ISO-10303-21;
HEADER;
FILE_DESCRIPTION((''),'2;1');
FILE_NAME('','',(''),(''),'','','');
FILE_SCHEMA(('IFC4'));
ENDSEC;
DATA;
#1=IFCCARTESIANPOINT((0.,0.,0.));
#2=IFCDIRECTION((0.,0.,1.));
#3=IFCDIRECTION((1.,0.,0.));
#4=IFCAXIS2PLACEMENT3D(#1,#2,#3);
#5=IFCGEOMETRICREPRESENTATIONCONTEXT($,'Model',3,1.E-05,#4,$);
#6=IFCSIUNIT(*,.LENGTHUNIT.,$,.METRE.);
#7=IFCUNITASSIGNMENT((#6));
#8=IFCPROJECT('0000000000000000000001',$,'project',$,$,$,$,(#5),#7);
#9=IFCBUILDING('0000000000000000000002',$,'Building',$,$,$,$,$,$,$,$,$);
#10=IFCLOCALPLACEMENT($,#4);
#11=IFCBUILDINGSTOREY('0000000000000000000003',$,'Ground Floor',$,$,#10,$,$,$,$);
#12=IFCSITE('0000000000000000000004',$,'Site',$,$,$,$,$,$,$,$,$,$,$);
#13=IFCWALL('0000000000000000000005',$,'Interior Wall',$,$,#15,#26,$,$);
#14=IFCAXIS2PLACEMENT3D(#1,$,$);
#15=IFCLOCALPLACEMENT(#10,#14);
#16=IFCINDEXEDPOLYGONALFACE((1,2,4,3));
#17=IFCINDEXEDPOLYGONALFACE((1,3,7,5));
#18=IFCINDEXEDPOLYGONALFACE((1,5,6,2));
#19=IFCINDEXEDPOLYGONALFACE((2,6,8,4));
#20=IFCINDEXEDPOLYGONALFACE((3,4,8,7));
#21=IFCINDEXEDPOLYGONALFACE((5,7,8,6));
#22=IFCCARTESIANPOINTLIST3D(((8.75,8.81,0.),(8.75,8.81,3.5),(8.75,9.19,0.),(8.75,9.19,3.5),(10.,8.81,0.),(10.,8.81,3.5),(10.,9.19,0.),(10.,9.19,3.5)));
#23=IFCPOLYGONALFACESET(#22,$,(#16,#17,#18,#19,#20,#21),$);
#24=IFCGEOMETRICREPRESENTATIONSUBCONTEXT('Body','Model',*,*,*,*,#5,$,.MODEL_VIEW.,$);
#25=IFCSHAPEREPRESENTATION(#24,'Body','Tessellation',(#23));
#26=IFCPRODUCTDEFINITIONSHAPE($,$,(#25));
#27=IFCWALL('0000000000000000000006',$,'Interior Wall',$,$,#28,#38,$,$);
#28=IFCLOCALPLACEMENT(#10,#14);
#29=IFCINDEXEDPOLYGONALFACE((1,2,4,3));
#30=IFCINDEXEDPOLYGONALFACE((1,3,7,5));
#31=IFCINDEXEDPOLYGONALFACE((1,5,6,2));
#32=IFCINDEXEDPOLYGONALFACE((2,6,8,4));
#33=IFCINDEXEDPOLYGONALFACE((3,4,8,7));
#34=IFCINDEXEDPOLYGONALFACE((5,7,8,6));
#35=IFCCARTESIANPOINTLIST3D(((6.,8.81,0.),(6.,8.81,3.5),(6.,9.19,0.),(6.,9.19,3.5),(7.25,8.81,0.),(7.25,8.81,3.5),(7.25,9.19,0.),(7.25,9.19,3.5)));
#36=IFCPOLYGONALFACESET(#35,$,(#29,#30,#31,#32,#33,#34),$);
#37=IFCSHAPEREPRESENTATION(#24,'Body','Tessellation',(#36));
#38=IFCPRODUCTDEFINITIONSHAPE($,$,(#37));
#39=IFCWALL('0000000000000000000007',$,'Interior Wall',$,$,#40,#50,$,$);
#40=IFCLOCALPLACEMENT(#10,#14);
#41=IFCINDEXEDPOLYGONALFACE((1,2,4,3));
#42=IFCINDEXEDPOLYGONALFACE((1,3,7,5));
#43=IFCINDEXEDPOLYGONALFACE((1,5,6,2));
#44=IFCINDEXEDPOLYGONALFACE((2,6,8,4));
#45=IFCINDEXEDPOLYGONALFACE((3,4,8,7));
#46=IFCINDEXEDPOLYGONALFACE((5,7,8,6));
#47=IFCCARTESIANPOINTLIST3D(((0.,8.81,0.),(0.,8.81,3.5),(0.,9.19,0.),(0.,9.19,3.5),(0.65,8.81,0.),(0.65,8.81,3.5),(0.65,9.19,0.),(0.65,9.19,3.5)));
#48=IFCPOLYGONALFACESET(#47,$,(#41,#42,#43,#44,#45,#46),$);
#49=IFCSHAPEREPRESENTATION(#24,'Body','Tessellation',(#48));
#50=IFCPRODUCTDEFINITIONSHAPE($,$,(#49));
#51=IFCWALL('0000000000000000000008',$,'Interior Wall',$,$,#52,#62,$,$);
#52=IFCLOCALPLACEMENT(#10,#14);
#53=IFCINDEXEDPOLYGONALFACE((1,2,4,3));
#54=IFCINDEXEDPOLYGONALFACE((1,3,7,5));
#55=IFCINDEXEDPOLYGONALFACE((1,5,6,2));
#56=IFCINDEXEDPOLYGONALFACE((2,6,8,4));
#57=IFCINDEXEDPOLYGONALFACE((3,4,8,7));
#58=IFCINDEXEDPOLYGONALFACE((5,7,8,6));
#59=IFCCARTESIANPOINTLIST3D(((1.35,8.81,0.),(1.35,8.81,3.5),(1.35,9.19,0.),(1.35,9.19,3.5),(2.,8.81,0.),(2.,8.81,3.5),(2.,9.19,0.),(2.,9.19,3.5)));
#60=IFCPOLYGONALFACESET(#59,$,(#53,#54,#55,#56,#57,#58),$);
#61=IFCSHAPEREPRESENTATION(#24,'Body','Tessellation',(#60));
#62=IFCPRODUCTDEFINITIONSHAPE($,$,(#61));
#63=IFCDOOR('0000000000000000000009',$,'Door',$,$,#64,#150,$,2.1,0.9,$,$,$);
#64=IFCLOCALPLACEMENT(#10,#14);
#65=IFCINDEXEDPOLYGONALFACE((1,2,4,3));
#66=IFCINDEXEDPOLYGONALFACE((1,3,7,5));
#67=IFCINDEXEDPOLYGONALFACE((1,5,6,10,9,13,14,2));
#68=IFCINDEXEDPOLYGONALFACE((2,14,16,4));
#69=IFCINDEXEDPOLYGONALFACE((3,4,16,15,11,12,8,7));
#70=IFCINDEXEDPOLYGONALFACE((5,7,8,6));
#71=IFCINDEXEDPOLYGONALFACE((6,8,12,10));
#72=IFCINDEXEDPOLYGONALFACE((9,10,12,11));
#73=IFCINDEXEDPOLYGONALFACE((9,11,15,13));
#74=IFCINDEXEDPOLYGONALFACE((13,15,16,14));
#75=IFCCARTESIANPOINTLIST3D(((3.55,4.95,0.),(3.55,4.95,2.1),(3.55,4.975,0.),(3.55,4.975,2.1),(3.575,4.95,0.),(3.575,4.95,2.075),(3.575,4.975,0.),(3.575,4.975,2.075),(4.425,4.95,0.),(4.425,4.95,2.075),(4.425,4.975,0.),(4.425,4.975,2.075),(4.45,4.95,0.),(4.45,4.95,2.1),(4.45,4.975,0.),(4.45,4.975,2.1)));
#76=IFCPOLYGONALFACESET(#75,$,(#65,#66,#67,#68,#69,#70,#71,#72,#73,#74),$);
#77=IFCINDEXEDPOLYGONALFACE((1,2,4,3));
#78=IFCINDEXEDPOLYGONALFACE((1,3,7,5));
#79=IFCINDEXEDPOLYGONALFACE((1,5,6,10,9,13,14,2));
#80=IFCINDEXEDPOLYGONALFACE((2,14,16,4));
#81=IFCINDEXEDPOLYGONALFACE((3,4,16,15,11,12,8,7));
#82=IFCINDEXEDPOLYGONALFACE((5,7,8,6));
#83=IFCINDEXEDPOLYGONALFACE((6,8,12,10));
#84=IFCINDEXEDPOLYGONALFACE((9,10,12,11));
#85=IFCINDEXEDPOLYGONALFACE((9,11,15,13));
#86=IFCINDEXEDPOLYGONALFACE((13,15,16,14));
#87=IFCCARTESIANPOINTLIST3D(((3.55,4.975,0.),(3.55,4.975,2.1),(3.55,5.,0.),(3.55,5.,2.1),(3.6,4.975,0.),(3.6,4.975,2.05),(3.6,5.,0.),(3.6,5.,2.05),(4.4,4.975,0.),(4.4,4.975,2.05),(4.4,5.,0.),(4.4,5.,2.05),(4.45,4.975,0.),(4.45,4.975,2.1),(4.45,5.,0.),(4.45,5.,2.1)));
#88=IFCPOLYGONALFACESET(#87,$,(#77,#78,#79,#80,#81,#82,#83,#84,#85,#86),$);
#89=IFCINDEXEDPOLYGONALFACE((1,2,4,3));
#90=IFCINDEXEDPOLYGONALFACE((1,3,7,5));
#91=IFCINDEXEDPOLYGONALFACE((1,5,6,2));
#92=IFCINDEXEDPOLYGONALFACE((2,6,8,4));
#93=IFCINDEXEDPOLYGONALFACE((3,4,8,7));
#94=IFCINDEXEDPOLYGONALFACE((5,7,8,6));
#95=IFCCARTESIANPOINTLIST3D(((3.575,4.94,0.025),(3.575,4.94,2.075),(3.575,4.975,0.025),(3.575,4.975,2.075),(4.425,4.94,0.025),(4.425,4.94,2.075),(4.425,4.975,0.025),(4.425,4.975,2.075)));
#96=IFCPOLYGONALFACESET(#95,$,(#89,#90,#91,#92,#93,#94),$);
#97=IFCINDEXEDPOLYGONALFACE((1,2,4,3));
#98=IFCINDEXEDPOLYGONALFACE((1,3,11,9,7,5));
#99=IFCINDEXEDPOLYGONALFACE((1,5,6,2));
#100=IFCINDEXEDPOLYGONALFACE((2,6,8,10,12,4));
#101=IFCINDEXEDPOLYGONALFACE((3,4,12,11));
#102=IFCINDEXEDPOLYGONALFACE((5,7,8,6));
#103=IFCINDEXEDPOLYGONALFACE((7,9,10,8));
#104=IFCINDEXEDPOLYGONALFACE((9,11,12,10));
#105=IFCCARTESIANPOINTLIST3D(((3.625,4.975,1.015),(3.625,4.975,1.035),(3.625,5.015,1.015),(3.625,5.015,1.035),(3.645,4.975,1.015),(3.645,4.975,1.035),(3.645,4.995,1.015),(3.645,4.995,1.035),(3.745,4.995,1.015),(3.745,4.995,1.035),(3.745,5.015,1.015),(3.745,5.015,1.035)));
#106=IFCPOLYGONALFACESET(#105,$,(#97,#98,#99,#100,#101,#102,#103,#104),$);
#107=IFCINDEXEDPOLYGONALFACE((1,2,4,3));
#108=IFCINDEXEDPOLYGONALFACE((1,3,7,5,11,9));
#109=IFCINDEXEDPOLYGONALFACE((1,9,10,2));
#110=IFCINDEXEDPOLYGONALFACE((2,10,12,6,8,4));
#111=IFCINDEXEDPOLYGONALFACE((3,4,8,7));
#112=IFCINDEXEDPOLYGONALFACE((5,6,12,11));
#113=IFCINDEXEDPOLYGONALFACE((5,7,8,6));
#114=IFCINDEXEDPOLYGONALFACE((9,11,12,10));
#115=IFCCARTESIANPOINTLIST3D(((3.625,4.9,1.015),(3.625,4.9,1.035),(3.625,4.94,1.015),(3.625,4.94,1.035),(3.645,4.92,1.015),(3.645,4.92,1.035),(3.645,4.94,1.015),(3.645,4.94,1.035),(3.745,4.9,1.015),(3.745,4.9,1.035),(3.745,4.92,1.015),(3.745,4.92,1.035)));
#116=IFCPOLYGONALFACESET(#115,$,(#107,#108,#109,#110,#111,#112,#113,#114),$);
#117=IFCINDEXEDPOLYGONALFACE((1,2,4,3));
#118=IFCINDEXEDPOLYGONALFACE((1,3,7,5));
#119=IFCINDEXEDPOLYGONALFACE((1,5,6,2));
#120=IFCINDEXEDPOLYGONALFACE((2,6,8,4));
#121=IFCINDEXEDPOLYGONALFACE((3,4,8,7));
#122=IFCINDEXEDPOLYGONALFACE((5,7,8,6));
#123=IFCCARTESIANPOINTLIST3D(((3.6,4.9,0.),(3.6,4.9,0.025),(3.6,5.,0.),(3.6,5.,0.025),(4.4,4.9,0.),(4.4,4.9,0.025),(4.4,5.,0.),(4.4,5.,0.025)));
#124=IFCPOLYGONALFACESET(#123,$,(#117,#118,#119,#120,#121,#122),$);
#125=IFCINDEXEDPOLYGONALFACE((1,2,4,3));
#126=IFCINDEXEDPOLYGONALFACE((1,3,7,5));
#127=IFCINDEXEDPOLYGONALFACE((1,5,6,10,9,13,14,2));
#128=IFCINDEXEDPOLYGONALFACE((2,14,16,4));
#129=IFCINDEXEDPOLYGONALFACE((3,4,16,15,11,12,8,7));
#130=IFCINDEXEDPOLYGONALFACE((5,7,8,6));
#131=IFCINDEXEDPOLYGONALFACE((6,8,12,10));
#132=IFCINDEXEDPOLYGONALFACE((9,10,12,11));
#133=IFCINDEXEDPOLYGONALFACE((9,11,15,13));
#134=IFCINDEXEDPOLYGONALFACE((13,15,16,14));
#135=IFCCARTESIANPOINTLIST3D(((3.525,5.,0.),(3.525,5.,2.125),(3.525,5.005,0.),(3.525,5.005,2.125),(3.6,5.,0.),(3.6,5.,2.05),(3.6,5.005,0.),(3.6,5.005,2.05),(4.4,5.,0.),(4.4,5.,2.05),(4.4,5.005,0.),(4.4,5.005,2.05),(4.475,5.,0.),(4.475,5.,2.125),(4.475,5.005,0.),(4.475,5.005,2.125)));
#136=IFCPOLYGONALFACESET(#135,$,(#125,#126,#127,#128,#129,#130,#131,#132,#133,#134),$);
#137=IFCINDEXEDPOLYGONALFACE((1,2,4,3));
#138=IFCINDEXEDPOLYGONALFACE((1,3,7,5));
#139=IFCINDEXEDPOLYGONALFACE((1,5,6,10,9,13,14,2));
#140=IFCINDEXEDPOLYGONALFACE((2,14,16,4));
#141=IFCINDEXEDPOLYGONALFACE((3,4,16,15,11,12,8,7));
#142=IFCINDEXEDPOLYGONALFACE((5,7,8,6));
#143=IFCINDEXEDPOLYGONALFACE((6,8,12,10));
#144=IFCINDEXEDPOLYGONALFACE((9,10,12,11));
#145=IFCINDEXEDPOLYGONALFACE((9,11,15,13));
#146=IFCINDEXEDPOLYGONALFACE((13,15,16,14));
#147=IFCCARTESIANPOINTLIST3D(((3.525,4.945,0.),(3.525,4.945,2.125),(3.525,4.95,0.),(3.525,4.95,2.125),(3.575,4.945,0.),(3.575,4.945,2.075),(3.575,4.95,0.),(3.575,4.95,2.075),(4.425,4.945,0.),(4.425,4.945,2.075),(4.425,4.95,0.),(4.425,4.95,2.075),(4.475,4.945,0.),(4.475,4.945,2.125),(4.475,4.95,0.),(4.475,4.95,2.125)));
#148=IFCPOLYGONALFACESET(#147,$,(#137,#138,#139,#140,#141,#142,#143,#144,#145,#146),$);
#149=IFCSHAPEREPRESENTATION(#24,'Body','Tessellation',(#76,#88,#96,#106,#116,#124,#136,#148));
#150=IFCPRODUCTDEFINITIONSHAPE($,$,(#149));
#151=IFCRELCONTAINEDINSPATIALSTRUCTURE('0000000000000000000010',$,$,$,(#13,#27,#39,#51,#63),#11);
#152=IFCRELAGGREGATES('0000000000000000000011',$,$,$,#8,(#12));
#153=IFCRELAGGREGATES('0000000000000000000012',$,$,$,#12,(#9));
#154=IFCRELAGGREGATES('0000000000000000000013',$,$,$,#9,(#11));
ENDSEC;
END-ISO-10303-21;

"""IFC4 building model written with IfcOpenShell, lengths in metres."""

from ifc_helpers import new_model, si_unit, frame, origin_with_axes, place, context, subcontext, project, spatial, line, indexed_curve, outline, extrude, element, save


model = new_model("IFC4")

# Units and contexts
model_context = context("Model", 3, precision=1e-05, world=origin_with_axes())
body_context = subcontext(model_context, "Body", "Model", "MODEL_VIEW")
ifc_project = project(units=[si_unit("LENGTHUNIT", "METRE")], contexts=[model_context])

# Site, building, storey
site = spatial("IfcSite", under=ifc_project, Name="Site")
building = spatial("IfcBuilding", under=site, Name="Building")
storey_placement = place(None, origin_with_axes())
storey = spatial("IfcBuildingStorey", under=building, at=storey_placement, Name="Ground Floor")

# Walls
for number, where, z_axis, x_axis, name in (
    (1, (10.0, 9.0, 0.0), (0.0, 0.0, 1.0), (-1.0, 0.0, 0.0), "Interior Wall"),
    (2, (7.25, 9.0, 0.0), (0.0, 0.0, 1.0), (-1.0, 0.0, 0.0), "Interior Wall"),
):
    element("IfcWall", number, at=place(storey_placement, frame(where, z_axis=z_axis, x_axis=x_axis)), inside=storey, Name=name, context=body_context, shape_type="SweptSolid", body=[
        extrude(outline(indexed_curve([(0.0, 0.0), (0.0, 0.38), (1.25, 0.38), (1.25, 0.0), (0.0, 0.0)], self_intersect=False)), frame((0.0, -0.19, 0.0), z_axis=(0.0, 0.0, 1.0), x_axis=(1.0, 0.0, 0.0)), (0.0, 0.0, 1.0), 3.5),
    ])
wall_1_placement = place(storey_placement, frame((0.0, 9.0, 0.0), z_axis=(0.0, 0.0, 1.0), x_axis=(1.0, 0.0, 0.0)))
element("IfcWall", 3, at=wall_1_placement, inside=storey, Name="Interior Wall", context=body_context, shape_type="SweptSolid", body=[
    extrude(outline(indexed_curve([(0.0, 0.0), (0.0, 0.38), (0.65, 0.38), (0.65, 0.0), (0.0, 0.0)], self_intersect=False)), frame((0.0, -0.19, 0.0), z_axis=(0.0, 0.0, 1.0), x_axis=(1.0, 0.0, 0.0)), (0.0, 0.0, 1.0), 3.5),
])
wall_2_placement = place(storey_placement, frame((1.35, 9.0, 0.0), z_axis=(0.0, 0.0, 1.0), x_axis=(1.0, 0.0, 0.0)))
element("IfcWall", 4, at=wall_2_placement, inside=storey, Name="Interior Wall", context=body_context, shape_type="SweptSolid", body=[
    extrude(outline(indexed_curve([(0.0, 0.0), (0.0, 0.38), (0.65, 0.38), (0.65, 0.0), (0.0, 0.0)], self_intersect=False)), frame((0.0, -0.19, 0.0), z_axis=(0.0, 0.0, 1.0), x_axis=(1.0, 0.0, 0.0)), (0.0, 0.0, 1.0), 3.5),
])

# Door
door_1_placement = place(storey_placement, frame((4.45, 5.0, 0.0), z_axis=(0.0, 0.0, 1.0), x_axis=(-1.0, 0.0, 0.0)))
element("IfcDoor", 5, at=door_1_placement, inside=storey, Name="Door", OverallHeight=2.1, OverallWidth=0.9, context=body_context, shape_type="SweptSolid", body=[
    extrude(outline(indexed_curve([(0.0, 0.0), (0.0, 2.1), (0.9, 2.1), (0.9, 0.0), (0.875, 0.0), (0.875, 2.075), (0.025, 2.075), (0.025, 0.0)], segments=[line(1, 2, 3, 4, 5, 6, 7, 8, 1)])), frame((0.0, 0.025, 0.0), z_axis=(0.0, -1.0, 0.0), x_axis=(1.0, 0.0, 0.0)), (0.0, 0.0, -1.0), 0.025),
    extrude(outline(indexed_curve([(0.0, 0.0), (0.0, 2.1), (0.9, 2.1), (0.9, 0.0), (0.85, 0.0), (0.85, 2.05), (0.05, 2.05), (0.05, 0.0)], segments=[line(1, 2, 3, 4, 5, 6, 7, 8, 1)])), frame((0.0, 0.0, 0.0), z_axis=(0.0, -1.0, 0.0), x_axis=(1.0, 0.0, 0.0)), (0.0, 0.0, -1.0), 0.025),
    extrude(outline(indexed_curve([(0.0, 0.0), (0.85, 0.0), (0.85, 0.035), (0.0, 0.035)], segments=[line(1, 2, 3, 4, 1)])), frame((0.025, 0.025, 0.025), z_axis=(0.0, 0.0, 1.0), x_axis=(1.0, 0.0, 0.0)), (0.0, 0.0, 1.0), 2.05),
    extrude(outline(indexed_curve([(0.0, 0.0), (0.0, -0.04), (-0.12, -0.04), (-0.12, -0.02), (-0.02, -0.02), (-0.02, 0.0)], segments=[line(1, 2, 3, 4, 5, 6, 1)])), frame((0.825, 0.025, 1.015), z_axis=(0.0, 0.0, 1.0), x_axis=(1.0, 0.0, 0.0)), (0.0, 0.0, 1.0), 0.02),
    extrude(outline(indexed_curve([(0.0, 0.0), (0.0, 0.04), (-0.12, 0.04), (-0.12, 0.02), (-0.02, 0.02), (-0.02, 0.0)], segments=[line(1, 2, 3, 4, 5, 6, 1)])), frame((0.825, 0.06, 1.015), z_axis=(0.0, 0.0, 1.0), x_axis=(1.0, 0.0, 0.0)), (0.0, 0.0, 1.0), 0.02),
    extrude(outline(indexed_curve([(0.0, 0.0), (0.8, 0.0), (0.8, 0.1), (0.0, 0.1)], segments=[line(1, 2, 3, 4, 1)])), frame((0.05, 0.0, 0.0), z_axis=(0.0, 0.0, 1.0), x_axis=(1.0, 0.0, 0.0)), (0.0, 0.0, 1.0), 0.025),
    extrude(outline(indexed_curve([(0.0, 0.0), (0.0, 2.125), (0.95, 2.125), (0.95, 0.0), (0.875, 0.0), (0.875, 2.05), (0.075, 2.05), (0.075, 0.0)], segments=[line(1, 2, 3, 4, 5, 6, 7, 8, 1)])), frame((-0.025, -0.005, 0.0), z_axis=(0.0, -1.0, 0.0), x_axis=(1.0, 0.0, 0.0)), (0.0, 0.0, -1.0), 0.005),
    extrude(outline(indexed_curve([(0.0, 0.0), (0.0, 2.125), (0.95, 2.125), (0.95, 0.0), (0.9, 0.0), (0.9, 2.075), (0.05, 2.075), (0.05, 0.0)], segments=[line(1, 2, 3, 4, 5, 6, 7, 8, 1)])), frame((-0.025, 0.05, 0.0), z_axis=(0.0, -1.0, 0.0), x_axis=(1.0, 0.0, 0.0)), (0.0, 0.0, -1.0), 0.005),
])

save(model, "model.ifc")
